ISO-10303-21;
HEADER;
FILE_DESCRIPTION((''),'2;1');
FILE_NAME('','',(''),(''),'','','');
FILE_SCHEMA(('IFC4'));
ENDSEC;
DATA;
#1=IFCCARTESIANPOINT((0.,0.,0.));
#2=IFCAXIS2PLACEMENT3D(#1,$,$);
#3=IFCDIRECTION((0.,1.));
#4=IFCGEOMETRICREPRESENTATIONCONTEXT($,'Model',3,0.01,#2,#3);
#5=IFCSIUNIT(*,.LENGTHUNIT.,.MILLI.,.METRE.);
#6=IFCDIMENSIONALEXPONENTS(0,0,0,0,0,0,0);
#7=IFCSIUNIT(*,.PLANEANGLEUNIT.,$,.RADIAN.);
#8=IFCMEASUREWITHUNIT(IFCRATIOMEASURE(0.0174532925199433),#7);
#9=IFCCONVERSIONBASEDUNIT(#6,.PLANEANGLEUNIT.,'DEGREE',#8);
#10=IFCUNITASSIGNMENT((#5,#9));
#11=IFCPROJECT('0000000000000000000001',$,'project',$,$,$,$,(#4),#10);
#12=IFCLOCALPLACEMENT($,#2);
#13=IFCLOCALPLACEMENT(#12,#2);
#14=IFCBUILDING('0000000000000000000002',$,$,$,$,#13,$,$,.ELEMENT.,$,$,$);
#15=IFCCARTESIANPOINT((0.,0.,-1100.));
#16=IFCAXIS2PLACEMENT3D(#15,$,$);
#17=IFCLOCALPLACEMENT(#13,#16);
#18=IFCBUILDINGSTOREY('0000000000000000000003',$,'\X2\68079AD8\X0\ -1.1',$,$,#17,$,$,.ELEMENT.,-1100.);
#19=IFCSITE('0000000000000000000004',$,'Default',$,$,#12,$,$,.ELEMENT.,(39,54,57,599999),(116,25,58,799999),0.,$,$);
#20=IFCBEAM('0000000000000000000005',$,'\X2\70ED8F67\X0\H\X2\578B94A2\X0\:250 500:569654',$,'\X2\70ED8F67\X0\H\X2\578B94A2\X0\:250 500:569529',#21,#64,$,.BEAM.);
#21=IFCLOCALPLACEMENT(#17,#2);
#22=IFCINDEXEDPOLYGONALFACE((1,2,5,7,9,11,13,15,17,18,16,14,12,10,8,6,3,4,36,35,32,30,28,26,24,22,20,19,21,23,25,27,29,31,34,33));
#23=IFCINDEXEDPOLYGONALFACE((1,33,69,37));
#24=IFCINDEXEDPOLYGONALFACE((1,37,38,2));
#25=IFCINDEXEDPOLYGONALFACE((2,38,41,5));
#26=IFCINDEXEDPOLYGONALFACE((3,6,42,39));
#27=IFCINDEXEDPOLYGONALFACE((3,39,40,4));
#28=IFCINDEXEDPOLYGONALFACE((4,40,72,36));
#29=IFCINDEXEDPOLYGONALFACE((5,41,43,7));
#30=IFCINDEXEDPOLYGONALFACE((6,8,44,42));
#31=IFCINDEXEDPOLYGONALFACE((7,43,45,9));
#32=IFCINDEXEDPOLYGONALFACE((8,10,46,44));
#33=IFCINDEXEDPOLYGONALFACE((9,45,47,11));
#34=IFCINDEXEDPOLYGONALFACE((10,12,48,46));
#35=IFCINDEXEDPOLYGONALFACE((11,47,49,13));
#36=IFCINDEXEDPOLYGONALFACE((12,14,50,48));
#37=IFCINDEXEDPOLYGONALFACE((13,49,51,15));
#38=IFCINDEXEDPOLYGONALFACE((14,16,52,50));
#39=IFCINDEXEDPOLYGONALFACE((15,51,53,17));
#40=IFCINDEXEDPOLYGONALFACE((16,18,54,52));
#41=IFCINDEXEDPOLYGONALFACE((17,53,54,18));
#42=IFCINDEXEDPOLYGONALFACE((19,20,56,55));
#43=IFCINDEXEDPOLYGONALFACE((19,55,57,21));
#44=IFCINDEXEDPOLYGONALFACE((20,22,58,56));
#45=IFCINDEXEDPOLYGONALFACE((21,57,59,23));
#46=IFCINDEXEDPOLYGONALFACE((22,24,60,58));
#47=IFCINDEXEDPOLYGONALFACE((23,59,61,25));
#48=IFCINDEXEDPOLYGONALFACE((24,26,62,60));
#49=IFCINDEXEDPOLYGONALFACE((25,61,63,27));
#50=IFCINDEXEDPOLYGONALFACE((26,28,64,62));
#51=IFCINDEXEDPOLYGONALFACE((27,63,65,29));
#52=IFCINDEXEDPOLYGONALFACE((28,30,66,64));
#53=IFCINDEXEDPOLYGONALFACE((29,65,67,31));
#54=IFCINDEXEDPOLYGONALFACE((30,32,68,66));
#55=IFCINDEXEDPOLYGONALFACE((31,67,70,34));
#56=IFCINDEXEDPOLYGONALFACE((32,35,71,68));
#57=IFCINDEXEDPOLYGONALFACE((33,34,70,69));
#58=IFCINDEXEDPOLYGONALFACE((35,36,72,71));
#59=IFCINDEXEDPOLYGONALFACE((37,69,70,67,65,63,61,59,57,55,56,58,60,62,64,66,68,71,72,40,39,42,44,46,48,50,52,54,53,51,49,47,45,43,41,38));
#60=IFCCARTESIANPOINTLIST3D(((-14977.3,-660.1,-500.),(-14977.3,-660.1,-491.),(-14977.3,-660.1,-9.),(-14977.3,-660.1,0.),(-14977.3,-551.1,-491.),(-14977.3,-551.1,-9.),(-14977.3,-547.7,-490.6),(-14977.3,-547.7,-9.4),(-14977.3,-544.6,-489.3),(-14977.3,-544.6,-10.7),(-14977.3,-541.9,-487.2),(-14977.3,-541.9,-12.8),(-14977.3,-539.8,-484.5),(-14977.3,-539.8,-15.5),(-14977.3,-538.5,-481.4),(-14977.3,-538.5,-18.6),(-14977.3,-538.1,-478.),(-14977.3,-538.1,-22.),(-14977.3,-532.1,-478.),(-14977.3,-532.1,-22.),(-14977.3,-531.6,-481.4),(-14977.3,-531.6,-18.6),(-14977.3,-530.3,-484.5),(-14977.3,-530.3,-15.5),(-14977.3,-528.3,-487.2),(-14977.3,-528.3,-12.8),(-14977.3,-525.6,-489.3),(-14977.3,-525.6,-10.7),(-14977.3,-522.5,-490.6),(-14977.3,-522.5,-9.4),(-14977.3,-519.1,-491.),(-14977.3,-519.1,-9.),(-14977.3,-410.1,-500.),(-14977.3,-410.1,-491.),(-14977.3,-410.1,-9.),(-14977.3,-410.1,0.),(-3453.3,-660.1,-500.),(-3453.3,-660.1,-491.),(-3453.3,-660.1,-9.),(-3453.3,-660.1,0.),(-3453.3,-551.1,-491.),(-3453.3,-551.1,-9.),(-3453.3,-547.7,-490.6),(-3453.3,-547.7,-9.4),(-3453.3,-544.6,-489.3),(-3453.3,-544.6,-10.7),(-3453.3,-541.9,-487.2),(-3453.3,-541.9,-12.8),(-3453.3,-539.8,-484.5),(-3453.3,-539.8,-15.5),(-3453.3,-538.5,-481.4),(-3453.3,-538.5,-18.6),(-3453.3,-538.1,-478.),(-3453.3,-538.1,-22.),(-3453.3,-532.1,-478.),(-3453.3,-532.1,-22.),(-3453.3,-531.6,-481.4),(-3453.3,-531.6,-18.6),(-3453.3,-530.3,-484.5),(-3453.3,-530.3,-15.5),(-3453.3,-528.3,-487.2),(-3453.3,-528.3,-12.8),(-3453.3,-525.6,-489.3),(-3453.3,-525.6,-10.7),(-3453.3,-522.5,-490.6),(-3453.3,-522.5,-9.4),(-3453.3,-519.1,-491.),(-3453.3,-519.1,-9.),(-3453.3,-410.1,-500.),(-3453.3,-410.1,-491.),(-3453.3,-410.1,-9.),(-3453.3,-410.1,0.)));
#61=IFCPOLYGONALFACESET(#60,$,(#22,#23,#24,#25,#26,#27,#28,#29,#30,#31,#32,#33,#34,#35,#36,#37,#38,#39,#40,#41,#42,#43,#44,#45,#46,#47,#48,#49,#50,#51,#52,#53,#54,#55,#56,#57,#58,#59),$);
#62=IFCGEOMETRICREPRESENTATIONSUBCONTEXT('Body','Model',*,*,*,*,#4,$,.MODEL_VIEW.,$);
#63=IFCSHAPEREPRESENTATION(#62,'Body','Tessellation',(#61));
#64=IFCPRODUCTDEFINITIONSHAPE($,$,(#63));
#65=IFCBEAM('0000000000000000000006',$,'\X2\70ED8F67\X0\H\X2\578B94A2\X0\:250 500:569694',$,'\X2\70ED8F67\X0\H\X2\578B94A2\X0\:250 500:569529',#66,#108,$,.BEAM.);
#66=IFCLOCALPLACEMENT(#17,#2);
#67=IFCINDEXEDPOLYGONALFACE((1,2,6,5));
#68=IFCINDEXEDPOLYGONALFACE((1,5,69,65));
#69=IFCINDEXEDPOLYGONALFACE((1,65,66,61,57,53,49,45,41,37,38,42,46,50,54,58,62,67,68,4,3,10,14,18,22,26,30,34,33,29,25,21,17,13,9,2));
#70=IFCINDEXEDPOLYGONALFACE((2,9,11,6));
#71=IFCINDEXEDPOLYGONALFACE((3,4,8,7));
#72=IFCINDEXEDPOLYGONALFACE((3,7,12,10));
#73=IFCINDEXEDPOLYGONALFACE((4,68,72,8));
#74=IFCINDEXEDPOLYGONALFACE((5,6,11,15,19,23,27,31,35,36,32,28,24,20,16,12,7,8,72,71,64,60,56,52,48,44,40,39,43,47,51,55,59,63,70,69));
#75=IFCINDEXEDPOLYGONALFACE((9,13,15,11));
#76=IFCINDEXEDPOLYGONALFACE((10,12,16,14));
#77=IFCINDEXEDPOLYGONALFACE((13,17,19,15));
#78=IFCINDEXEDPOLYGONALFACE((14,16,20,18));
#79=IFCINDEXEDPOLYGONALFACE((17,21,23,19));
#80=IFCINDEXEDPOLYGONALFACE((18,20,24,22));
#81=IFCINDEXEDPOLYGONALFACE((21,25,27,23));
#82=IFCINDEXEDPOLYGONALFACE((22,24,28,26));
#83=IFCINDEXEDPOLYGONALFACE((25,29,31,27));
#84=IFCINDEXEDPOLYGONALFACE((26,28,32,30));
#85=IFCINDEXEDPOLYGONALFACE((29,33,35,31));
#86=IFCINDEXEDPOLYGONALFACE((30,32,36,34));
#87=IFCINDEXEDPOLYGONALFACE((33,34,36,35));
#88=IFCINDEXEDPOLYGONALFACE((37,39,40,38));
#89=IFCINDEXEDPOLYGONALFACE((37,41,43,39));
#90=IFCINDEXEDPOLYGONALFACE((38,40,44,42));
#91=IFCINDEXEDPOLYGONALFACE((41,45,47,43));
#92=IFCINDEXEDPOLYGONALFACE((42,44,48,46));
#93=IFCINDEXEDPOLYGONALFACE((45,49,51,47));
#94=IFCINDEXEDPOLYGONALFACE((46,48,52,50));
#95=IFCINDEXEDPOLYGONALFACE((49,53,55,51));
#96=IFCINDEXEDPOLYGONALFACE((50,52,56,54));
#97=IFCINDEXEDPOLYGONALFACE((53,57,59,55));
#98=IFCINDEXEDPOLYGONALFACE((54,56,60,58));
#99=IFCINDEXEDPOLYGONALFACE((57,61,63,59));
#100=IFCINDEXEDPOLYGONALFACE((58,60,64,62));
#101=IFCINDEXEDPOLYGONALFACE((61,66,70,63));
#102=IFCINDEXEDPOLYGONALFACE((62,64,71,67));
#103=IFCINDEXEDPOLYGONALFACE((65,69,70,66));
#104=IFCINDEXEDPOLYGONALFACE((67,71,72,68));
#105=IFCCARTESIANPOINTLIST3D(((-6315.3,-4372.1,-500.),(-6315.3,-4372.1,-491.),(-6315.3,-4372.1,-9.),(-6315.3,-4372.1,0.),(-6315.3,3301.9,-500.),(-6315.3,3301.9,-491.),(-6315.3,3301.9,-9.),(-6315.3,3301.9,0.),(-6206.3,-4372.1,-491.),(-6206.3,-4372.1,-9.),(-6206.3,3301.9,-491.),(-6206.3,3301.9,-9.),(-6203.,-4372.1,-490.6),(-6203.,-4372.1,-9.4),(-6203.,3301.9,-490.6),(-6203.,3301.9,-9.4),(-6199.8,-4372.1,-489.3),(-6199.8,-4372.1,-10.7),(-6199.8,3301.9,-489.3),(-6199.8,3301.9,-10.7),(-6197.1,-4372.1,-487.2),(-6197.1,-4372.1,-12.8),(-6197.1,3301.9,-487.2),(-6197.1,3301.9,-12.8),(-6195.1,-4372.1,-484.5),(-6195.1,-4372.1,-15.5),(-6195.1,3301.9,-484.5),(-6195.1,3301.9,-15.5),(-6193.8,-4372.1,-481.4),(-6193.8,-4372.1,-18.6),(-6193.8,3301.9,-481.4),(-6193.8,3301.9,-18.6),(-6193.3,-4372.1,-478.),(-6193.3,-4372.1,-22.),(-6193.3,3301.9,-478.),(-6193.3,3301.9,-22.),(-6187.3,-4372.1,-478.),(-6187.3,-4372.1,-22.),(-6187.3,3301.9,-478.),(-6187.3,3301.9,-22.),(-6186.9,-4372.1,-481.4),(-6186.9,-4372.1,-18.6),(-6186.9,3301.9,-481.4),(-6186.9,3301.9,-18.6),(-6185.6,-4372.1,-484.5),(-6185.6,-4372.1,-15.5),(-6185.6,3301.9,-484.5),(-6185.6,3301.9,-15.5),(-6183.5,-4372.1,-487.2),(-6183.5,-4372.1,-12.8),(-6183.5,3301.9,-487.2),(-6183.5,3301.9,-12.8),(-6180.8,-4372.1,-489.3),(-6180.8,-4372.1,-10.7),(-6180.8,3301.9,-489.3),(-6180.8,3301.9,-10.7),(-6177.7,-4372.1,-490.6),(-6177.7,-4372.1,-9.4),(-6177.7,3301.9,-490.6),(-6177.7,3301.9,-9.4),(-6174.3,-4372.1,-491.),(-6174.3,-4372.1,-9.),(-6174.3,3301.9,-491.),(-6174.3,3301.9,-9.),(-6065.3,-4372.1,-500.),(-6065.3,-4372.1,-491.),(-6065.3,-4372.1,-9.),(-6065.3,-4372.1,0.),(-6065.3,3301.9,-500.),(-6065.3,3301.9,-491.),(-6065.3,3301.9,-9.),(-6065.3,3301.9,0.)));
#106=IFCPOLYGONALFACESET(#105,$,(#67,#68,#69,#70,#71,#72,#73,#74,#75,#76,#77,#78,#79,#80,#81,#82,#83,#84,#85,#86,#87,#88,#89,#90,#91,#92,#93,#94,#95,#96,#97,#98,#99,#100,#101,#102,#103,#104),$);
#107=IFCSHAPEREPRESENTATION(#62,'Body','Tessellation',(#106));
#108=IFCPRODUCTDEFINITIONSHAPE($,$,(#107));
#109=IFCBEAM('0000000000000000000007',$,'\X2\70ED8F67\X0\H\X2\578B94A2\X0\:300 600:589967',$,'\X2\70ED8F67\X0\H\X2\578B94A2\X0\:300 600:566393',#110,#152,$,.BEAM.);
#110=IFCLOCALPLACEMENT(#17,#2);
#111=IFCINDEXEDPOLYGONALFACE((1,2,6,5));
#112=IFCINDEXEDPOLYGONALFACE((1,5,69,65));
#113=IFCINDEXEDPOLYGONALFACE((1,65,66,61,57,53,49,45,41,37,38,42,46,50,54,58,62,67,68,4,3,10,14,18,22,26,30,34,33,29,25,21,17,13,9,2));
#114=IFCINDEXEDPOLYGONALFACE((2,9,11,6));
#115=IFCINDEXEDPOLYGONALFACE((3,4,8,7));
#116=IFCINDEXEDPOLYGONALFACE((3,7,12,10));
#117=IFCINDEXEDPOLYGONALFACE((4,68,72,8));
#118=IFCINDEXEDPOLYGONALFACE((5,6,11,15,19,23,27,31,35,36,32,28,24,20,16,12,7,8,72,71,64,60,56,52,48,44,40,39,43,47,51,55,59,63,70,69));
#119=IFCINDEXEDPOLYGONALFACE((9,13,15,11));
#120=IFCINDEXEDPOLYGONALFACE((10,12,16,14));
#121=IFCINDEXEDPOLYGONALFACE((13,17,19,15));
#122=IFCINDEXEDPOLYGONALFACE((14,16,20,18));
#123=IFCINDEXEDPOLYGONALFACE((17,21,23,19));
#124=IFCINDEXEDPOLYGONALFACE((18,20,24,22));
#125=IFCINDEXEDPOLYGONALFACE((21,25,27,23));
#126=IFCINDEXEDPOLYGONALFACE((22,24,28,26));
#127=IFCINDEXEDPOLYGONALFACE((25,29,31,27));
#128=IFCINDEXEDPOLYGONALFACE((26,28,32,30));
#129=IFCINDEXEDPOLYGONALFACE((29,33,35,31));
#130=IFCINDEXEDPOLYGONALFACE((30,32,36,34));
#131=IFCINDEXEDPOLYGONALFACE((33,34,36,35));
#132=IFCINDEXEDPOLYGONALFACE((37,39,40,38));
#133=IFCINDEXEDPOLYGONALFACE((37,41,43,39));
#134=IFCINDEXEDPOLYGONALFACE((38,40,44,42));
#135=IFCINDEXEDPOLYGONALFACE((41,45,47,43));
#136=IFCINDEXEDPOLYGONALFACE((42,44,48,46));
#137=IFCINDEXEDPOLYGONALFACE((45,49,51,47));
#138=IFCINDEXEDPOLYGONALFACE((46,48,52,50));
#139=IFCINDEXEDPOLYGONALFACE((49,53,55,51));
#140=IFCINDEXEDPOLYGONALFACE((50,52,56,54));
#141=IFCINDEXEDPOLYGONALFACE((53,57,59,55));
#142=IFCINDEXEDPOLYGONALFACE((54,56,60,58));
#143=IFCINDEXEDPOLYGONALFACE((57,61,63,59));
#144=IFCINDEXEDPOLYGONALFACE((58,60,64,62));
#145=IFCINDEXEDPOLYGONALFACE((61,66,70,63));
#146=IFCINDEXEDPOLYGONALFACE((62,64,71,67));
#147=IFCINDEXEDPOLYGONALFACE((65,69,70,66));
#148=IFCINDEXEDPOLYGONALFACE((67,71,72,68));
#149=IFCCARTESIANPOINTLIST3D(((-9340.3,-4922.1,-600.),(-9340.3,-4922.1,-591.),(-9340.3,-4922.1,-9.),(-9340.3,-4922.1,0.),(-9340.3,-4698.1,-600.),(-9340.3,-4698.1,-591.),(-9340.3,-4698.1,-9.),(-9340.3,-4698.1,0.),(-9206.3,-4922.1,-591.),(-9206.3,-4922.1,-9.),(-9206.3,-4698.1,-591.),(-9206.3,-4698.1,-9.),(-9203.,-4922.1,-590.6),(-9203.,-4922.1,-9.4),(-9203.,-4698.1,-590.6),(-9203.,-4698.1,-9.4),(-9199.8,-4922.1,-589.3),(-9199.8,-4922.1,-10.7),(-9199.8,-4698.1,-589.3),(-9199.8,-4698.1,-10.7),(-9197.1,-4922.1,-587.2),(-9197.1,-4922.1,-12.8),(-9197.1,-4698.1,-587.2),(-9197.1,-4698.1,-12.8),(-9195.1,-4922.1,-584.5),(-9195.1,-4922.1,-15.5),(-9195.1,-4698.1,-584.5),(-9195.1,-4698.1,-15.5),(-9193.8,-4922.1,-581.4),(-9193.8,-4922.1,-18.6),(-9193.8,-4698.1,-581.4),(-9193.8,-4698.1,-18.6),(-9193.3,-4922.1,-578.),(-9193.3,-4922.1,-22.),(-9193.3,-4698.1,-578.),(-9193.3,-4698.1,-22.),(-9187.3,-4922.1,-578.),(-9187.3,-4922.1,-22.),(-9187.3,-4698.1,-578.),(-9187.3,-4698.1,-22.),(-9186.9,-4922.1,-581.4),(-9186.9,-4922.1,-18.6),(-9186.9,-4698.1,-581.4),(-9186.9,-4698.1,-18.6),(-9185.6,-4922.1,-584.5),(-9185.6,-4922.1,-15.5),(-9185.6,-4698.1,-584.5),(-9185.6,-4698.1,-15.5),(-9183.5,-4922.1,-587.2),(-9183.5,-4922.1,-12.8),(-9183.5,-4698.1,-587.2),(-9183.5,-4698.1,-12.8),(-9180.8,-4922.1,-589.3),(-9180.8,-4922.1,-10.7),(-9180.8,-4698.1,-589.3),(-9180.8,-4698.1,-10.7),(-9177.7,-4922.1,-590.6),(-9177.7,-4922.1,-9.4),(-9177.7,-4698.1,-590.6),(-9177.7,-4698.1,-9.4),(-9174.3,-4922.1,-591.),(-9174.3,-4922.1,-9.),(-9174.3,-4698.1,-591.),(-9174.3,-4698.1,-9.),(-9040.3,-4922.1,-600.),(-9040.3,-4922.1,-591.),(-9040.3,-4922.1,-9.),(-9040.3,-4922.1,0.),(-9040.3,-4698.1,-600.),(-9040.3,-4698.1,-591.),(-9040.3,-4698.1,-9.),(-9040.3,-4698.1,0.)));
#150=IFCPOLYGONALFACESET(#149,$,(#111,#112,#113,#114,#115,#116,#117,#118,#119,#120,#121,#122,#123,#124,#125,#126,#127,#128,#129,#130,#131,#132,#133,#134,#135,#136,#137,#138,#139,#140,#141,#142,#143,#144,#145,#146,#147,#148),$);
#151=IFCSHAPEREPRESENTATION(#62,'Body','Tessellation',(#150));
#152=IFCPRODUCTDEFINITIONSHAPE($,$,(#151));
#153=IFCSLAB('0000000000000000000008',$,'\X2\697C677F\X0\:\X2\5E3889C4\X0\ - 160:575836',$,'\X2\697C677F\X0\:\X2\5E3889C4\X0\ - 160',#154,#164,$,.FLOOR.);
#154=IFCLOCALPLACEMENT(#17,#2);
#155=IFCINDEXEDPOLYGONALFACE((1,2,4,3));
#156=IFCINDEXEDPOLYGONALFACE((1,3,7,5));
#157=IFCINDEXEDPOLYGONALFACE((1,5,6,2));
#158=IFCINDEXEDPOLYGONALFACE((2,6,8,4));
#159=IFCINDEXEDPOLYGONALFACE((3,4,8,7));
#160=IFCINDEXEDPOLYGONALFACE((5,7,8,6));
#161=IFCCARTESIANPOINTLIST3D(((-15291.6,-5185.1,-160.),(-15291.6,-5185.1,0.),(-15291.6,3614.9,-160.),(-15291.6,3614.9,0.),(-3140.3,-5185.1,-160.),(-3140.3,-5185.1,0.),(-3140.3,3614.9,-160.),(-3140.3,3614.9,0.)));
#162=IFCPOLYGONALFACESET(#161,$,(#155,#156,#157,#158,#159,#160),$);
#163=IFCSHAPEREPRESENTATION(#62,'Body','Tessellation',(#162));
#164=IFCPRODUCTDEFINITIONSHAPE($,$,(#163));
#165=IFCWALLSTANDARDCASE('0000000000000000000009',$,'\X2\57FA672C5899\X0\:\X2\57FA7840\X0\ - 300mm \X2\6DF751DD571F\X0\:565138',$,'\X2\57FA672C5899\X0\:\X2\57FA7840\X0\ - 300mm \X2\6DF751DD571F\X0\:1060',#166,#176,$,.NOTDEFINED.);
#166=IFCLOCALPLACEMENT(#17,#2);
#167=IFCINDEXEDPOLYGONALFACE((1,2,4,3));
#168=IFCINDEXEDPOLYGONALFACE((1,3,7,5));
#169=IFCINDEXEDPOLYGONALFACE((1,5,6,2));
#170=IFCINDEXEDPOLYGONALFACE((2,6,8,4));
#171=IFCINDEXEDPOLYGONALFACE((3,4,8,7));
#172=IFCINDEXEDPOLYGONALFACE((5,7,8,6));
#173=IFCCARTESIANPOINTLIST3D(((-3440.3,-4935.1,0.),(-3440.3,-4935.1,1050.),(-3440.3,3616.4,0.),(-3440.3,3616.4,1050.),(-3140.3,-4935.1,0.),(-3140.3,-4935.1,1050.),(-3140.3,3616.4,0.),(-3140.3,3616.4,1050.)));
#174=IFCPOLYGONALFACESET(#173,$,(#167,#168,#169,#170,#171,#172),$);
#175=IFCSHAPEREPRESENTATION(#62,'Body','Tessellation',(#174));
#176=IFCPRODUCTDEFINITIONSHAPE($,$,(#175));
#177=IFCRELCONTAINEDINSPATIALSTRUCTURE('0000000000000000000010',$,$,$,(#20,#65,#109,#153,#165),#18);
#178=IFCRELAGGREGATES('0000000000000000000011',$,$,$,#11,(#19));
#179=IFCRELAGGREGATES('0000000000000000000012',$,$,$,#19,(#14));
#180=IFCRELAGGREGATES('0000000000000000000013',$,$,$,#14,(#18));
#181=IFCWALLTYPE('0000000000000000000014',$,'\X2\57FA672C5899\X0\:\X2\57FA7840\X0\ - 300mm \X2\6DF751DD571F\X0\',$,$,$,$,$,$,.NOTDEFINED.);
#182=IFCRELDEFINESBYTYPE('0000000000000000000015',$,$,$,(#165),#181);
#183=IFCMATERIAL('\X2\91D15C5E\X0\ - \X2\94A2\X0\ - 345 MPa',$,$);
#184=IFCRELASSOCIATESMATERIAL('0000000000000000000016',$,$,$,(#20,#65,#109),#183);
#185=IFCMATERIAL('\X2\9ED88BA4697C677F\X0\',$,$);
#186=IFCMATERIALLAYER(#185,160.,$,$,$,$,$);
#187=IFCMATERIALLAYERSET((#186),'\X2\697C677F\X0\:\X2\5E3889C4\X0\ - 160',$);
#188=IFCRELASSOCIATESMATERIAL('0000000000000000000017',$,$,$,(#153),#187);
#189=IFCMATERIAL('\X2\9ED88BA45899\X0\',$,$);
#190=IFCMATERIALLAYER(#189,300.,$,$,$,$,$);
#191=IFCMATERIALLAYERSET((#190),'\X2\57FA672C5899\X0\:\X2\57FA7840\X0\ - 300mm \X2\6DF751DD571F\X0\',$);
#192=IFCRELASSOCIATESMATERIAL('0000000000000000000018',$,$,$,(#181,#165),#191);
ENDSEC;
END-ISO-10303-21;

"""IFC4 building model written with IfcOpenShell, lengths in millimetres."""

from ifc_helpers import new_model, entity, si_unit, converted_unit, direction, frame, frame_2d, origin, origin_2d_with_axis, place, context, subcontext, project, spatial, rectangle, i_section, extrude, material, layer, layer_set, layer_usage, type_object, element, save


model = new_model("IFC4")

# Units and contexts
model_context = context("Model", 3, precision=0.01, world=origin(), true_north=direction((0.0, 1.0)))
body_context = subcontext(model_context, "Body", "Model", "MODEL_VIEW")
ifc_project = project(units=[si_unit("LENGTHUNIT", "METRE", prefix="MILLI"), converted_unit("PLANEANGLEUNIT", "DEGREE", entity("IfcRatioMeasure", 0.0174532925199433), si_unit("PLANEANGLEUNIT", "RADIAN"), dimensions=[0, 0, 0, 0, 0, 0, 0])], contexts=[model_context])

# Site, building, storey
site_placement = place(None, origin())
site = spatial("IfcSite", under=ifc_project, at=site_placement, Name="Default", CompositionType="ELEMENT", RefLatitude=(39, 54, 57, 599999), RefLongitude=(116, 25, 58, 799999), RefElevation=0.0)
building_placement = place(site_placement, origin())
building = spatial("IfcBuilding", under=site, at=building_placement, CompositionType="ELEMENT")
storey_placement = place(building_placement, frame((0.0, 0.0, -1100.0)))
storey = spatial("IfcBuildingStorey", under=building, at=storey_placement, Name="标高 -1.1", CompositionType="ELEMENT", Elevation=-1100.0)

# Beams
ifc_material_1 = material(Name="金属 - 钢 - 345 MPa")
beam_1_placement = place(storey_placement, frame((-15140.3, -535.1, 0.0)))
element("IfcBeam", 1, at=beam_1_placement, inside=storey, material=ifc_material_1, Name="热轧H型钢:250 500:569654", ObjectType="热轧H型钢:250 500:569529", PredefinedType="BEAM", context=body_context, shape_type="SweptSolid", body=[
    extrude(i_section(OverallWidth=250.0, OverallDepth=500.0, WebThickness=6.0, FlangeThickness=9.0, FilletRadius=13.0, at=frame_2d((0.0, 0.0), x_axis=(0.0, 1.0))), frame((163.0, 0.0, -250.0), z_axis=(1.0, 0.0, 0.0), x_axis=(0.0, 0.0, -1.0)), (0.0, 0.0, 1.0), 11524.0),
])
beam_2_placement = place(storey_placement, frame((-6190.3, 3464.9, 0.0), z_axis=(0.0, 0.0, 1.0), x_axis=(0.0, -1.0, 0.0)))
element("IfcBeam", 2, at=beam_2_placement, inside=storey, material=ifc_material_1, Name="热轧H型钢:250 500:569694", ObjectType="热轧H型钢:250 500:569529", PredefinedType="BEAM", context=body_context, shape_type="SweptSolid", body=[
    extrude(i_section(OverallWidth=250.0, OverallDepth=500.0, WebThickness=6.0, FlangeThickness=9.0, FilletRadius=13.0, at=frame_2d((0.0, 0.0), x_axis=(0.0, 1.0))), frame((163.0, 0.0, -250.0), z_axis=(1.0, 0.0, 0.0), x_axis=(0.0, 0.0, -1.0)), (0.0, 0.0, 1.0), 7674.0),
])
beam_3_placement = place(storey_placement, frame((-9190.3, -4165.1, 0.0), z_axis=(0.0, 0.0, 1.0), x_axis=(0.0, -1.0, 0.0)))
element("IfcBeam", 3, at=beam_3_placement, inside=storey, material=ifc_material_1, Name="热轧H型钢:300 600:589967", ObjectType="热轧H型钢:300 600:566393", PredefinedType="BEAM", context=body_context, shape_type="SweptSolid", body=[
    extrude(i_section(OverallWidth=300.0, OverallDepth=600.0, WebThickness=6.0, FlangeThickness=9.0, FilletRadius=13.0, at=frame_2d((0.0, 0.0), x_axis=(0.0, 1.0))), frame((533.0, 0.0, -300.0), z_axis=(1.0, 0.0, 0.0), x_axis=(0.0, 0.0, -1.0)), (0.0, 0.0, 1.0), 224.0),
])

# Slab
ifc_material_2 = material(Name="默认楼板")
ifc_layer_1 = layer(ifc_material_2, 160.0)
ifc_layer_set_1 = layer_set([ifc_layer_1], Name="楼板:常规 - 160")
ifc_layer_usage_1 = layer_usage(ifc_layer_set_1, "AXIS3", "POSITIVE", 0.0)
slab_placement = place(storey_placement, origin())
element("IfcSlab", 4, at=slab_placement, inside=storey, material=ifc_layer_usage_1, Name="楼板:常规 - 160:575836", ObjectType="楼板:常规 - 160", PredefinedType="FLOOR", context=body_context, shape_type="SweptSolid", body=[
    extrude(rectangle(XDim=8800.0, YDim=12151.3, at=origin_2d_with_axis()), frame((-9216.0, -785.1, 0.0), z_axis=(0.0, 0.0, -1.0), x_axis=(0.0, 1.0, 0.0)), (0.0, 0.0, 1.0), 160.0),
])

# Wall
ifc_material_3 = material(Name="默认墙")
ifc_layer_2 = layer(ifc_material_3, 300.0)
ifc_layer_set_2 = layer_set([ifc_layer_2], Name="基本墙:基础 - 300mm 混凝土")
ifc_layer_usage_2 = layer_usage(ifc_layer_set_2, "AXIS2", "NEGATIVE", 150.0)
wall_type = type_object("IfcWallType", Name="基本墙:基础 - 300mm 混凝土", PredefinedType="NOTDEFINED", material=ifc_layer_set_2)
wall_placement = place(storey_placement, frame((-3290.3, 3616.4, 0.0), z_axis=(0.0, 0.0, 1.0), x_axis=(0.0, -1.0, 0.0)))
element("IfcWallStandardCase", 5, at=wall_placement, inside=storey, type_object=wall_type, material=ifc_layer_usage_2, Name="基本墙:基础 - 300mm 混凝土:565138", ObjectType="基本墙:基础 - 300mm 混凝土:1060", PredefinedType="NOTDEFINED", context=body_context, shape_type="SweptSolid", body=[
    extrude(rectangle(XDim=8551.5, YDim=300.0, at=frame_2d((4275.8, 0.0), x_axis=(-1.0, 0.0))), origin(), (0.0, 0.0, 1.0), 1050.0),
])

save(model, "model.ifc")
